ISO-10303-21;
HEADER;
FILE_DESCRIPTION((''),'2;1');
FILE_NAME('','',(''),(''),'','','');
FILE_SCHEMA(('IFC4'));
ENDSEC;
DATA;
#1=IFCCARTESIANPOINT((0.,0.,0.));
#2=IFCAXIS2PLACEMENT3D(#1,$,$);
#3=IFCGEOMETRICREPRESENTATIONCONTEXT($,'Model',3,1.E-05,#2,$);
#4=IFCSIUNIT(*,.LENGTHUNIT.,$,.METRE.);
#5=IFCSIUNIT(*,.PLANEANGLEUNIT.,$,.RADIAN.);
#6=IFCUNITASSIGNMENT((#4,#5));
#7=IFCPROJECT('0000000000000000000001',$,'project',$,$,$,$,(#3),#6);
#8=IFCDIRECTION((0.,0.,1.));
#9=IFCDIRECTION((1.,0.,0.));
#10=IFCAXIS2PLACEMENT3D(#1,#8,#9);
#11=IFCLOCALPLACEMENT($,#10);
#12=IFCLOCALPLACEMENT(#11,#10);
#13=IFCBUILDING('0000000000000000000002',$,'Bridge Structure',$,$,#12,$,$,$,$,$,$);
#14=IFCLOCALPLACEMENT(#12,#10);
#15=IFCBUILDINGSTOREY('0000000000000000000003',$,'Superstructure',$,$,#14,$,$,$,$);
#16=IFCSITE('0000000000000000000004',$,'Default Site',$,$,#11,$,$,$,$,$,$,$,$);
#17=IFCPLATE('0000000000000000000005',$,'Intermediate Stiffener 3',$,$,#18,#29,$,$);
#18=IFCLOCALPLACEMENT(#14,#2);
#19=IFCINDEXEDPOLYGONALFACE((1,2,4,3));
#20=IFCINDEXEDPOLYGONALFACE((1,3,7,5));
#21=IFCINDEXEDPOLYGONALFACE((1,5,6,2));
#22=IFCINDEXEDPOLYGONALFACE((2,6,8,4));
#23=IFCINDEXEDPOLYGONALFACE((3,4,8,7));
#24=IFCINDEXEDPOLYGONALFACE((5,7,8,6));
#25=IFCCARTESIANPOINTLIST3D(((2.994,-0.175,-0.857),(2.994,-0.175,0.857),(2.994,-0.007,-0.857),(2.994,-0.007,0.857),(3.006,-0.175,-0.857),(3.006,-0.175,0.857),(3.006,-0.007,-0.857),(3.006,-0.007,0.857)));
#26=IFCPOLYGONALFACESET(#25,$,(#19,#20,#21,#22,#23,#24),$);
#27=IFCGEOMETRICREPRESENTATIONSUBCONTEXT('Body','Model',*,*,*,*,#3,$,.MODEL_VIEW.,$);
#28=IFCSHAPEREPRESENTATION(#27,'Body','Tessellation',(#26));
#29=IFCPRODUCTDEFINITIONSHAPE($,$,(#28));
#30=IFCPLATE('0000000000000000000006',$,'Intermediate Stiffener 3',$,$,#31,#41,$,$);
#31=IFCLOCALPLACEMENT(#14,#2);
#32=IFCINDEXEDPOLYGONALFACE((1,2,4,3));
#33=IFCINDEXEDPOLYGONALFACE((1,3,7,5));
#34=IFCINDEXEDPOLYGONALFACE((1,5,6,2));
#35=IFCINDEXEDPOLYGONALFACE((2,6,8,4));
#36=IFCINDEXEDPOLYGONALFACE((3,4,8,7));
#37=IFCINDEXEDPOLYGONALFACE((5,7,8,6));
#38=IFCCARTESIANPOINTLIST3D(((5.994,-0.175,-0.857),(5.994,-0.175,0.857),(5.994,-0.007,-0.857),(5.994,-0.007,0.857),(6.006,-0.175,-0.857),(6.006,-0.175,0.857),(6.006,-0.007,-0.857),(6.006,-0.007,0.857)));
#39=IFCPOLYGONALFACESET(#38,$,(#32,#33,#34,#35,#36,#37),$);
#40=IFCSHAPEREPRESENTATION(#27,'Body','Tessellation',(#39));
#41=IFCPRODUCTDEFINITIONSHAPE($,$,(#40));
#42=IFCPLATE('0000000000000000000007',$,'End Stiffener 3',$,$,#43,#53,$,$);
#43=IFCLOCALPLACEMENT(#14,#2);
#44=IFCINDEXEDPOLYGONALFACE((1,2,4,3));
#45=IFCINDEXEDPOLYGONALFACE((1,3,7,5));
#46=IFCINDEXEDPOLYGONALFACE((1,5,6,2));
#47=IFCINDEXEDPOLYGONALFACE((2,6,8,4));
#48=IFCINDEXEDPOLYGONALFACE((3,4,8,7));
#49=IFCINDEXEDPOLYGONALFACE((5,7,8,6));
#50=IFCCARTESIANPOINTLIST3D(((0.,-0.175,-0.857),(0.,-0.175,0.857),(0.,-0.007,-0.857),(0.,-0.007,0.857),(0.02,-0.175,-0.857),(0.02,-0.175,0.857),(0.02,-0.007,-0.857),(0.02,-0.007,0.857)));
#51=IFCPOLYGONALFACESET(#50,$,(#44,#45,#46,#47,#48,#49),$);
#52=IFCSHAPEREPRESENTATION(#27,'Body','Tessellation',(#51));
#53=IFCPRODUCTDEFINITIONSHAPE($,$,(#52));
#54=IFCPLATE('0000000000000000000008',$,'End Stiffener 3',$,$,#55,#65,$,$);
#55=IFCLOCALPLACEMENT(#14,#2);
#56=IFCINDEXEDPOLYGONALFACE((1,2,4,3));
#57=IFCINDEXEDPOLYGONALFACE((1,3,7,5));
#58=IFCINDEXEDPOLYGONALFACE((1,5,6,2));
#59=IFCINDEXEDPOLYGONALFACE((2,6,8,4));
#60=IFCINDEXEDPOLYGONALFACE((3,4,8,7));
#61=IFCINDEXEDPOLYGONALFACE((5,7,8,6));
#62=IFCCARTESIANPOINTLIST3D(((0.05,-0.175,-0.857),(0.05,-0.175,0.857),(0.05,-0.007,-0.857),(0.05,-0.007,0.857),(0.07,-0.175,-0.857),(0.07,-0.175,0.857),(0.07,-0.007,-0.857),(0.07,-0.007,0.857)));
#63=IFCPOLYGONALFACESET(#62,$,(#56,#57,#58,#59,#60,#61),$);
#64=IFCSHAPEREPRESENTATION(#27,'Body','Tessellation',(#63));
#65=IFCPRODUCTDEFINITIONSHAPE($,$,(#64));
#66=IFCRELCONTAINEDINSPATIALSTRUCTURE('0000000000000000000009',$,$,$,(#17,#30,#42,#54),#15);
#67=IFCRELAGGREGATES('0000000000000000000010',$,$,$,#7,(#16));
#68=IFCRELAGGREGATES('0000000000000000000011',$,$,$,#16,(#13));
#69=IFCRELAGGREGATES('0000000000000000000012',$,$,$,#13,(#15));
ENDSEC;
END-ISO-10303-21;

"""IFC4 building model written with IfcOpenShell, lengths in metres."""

from ifc_helpers import new_model, si_unit, frame, origin, origin_with_axes, origin_2d_with_axis, place, context, subcontext, project, spatial, rectangle, extrude, element, save


model = new_model("IFC4")

# Units and contexts
model_context = context("Model", 3, precision=1e-05, world=origin())
body_context = subcontext(model_context, "Body", "Model", "MODEL_VIEW")
ifc_project = project(units=[si_unit("LENGTHUNIT", "METRE"), si_unit("PLANEANGLEUNIT", "RADIAN")], contexts=[model_context])

# Site, building, storey
site_placement = place(None, origin_with_axes())
site = spatial("IfcSite", under=ifc_project, at=site_placement, Name="Default Site")
building_placement = place(site_placement, origin_with_axes())
building = spatial("IfcBuilding", under=site, at=building_placement, Name="Bridge Structure")
storey_placement = place(building_placement, origin_with_axes())
storey = spatial("IfcBuildingStorey", under=building, at=storey_placement, Name="Superstructure")

# Plates
for number, where, z_axis, x_axis, name in (
    (1, (3.0, -0.091, -0.857), (0.0, 0.0, 1.0), (1.0, 0.0, 0.0), "Intermediate Stiffener 3"),
    (2, (6.0, -0.091, -0.857), (0.0, 0.0, 1.0), (1.0, 0.0, 0.0), "Intermediate Stiffener 3"),
):
    element("IfcPlate", number, at=place(storey_placement, frame(where, z_axis=z_axis, x_axis=x_axis)), inside=storey, Name=name, context=body_context, shape_type="SweptSolid", body=[
        extrude(rectangle(XDim=0.012, YDim=0.168, at=origin_2d_with_axis()), origin_with_axes(), (0.0, 0.0, 1.0), 1.714),
    ])
for number, where, z_axis, x_axis, name in (
    (3, (0.01, -0.091, -0.857), (0.0, 0.0, 1.0), (1.0, 0.0, 0.0), "End Stiffener 3"),
    (4, (0.06, -0.091, -0.857), (0.0, 0.0, 1.0), (1.0, 0.0, 0.0), "End Stiffener 3"),
):
    element("IfcPlate", number, at=place(storey_placement, frame(where, z_axis=z_axis, x_axis=x_axis)), inside=storey, Name=name, context=body_context, shape_type="SweptSolid", body=[
        extrude(rectangle(XDim=0.02, YDim=0.168, at=origin_2d_with_axis()), origin_with_axes(), (0.0, 0.0, 1.0), 1.714),
    ])

save(model, "model.ifc")
